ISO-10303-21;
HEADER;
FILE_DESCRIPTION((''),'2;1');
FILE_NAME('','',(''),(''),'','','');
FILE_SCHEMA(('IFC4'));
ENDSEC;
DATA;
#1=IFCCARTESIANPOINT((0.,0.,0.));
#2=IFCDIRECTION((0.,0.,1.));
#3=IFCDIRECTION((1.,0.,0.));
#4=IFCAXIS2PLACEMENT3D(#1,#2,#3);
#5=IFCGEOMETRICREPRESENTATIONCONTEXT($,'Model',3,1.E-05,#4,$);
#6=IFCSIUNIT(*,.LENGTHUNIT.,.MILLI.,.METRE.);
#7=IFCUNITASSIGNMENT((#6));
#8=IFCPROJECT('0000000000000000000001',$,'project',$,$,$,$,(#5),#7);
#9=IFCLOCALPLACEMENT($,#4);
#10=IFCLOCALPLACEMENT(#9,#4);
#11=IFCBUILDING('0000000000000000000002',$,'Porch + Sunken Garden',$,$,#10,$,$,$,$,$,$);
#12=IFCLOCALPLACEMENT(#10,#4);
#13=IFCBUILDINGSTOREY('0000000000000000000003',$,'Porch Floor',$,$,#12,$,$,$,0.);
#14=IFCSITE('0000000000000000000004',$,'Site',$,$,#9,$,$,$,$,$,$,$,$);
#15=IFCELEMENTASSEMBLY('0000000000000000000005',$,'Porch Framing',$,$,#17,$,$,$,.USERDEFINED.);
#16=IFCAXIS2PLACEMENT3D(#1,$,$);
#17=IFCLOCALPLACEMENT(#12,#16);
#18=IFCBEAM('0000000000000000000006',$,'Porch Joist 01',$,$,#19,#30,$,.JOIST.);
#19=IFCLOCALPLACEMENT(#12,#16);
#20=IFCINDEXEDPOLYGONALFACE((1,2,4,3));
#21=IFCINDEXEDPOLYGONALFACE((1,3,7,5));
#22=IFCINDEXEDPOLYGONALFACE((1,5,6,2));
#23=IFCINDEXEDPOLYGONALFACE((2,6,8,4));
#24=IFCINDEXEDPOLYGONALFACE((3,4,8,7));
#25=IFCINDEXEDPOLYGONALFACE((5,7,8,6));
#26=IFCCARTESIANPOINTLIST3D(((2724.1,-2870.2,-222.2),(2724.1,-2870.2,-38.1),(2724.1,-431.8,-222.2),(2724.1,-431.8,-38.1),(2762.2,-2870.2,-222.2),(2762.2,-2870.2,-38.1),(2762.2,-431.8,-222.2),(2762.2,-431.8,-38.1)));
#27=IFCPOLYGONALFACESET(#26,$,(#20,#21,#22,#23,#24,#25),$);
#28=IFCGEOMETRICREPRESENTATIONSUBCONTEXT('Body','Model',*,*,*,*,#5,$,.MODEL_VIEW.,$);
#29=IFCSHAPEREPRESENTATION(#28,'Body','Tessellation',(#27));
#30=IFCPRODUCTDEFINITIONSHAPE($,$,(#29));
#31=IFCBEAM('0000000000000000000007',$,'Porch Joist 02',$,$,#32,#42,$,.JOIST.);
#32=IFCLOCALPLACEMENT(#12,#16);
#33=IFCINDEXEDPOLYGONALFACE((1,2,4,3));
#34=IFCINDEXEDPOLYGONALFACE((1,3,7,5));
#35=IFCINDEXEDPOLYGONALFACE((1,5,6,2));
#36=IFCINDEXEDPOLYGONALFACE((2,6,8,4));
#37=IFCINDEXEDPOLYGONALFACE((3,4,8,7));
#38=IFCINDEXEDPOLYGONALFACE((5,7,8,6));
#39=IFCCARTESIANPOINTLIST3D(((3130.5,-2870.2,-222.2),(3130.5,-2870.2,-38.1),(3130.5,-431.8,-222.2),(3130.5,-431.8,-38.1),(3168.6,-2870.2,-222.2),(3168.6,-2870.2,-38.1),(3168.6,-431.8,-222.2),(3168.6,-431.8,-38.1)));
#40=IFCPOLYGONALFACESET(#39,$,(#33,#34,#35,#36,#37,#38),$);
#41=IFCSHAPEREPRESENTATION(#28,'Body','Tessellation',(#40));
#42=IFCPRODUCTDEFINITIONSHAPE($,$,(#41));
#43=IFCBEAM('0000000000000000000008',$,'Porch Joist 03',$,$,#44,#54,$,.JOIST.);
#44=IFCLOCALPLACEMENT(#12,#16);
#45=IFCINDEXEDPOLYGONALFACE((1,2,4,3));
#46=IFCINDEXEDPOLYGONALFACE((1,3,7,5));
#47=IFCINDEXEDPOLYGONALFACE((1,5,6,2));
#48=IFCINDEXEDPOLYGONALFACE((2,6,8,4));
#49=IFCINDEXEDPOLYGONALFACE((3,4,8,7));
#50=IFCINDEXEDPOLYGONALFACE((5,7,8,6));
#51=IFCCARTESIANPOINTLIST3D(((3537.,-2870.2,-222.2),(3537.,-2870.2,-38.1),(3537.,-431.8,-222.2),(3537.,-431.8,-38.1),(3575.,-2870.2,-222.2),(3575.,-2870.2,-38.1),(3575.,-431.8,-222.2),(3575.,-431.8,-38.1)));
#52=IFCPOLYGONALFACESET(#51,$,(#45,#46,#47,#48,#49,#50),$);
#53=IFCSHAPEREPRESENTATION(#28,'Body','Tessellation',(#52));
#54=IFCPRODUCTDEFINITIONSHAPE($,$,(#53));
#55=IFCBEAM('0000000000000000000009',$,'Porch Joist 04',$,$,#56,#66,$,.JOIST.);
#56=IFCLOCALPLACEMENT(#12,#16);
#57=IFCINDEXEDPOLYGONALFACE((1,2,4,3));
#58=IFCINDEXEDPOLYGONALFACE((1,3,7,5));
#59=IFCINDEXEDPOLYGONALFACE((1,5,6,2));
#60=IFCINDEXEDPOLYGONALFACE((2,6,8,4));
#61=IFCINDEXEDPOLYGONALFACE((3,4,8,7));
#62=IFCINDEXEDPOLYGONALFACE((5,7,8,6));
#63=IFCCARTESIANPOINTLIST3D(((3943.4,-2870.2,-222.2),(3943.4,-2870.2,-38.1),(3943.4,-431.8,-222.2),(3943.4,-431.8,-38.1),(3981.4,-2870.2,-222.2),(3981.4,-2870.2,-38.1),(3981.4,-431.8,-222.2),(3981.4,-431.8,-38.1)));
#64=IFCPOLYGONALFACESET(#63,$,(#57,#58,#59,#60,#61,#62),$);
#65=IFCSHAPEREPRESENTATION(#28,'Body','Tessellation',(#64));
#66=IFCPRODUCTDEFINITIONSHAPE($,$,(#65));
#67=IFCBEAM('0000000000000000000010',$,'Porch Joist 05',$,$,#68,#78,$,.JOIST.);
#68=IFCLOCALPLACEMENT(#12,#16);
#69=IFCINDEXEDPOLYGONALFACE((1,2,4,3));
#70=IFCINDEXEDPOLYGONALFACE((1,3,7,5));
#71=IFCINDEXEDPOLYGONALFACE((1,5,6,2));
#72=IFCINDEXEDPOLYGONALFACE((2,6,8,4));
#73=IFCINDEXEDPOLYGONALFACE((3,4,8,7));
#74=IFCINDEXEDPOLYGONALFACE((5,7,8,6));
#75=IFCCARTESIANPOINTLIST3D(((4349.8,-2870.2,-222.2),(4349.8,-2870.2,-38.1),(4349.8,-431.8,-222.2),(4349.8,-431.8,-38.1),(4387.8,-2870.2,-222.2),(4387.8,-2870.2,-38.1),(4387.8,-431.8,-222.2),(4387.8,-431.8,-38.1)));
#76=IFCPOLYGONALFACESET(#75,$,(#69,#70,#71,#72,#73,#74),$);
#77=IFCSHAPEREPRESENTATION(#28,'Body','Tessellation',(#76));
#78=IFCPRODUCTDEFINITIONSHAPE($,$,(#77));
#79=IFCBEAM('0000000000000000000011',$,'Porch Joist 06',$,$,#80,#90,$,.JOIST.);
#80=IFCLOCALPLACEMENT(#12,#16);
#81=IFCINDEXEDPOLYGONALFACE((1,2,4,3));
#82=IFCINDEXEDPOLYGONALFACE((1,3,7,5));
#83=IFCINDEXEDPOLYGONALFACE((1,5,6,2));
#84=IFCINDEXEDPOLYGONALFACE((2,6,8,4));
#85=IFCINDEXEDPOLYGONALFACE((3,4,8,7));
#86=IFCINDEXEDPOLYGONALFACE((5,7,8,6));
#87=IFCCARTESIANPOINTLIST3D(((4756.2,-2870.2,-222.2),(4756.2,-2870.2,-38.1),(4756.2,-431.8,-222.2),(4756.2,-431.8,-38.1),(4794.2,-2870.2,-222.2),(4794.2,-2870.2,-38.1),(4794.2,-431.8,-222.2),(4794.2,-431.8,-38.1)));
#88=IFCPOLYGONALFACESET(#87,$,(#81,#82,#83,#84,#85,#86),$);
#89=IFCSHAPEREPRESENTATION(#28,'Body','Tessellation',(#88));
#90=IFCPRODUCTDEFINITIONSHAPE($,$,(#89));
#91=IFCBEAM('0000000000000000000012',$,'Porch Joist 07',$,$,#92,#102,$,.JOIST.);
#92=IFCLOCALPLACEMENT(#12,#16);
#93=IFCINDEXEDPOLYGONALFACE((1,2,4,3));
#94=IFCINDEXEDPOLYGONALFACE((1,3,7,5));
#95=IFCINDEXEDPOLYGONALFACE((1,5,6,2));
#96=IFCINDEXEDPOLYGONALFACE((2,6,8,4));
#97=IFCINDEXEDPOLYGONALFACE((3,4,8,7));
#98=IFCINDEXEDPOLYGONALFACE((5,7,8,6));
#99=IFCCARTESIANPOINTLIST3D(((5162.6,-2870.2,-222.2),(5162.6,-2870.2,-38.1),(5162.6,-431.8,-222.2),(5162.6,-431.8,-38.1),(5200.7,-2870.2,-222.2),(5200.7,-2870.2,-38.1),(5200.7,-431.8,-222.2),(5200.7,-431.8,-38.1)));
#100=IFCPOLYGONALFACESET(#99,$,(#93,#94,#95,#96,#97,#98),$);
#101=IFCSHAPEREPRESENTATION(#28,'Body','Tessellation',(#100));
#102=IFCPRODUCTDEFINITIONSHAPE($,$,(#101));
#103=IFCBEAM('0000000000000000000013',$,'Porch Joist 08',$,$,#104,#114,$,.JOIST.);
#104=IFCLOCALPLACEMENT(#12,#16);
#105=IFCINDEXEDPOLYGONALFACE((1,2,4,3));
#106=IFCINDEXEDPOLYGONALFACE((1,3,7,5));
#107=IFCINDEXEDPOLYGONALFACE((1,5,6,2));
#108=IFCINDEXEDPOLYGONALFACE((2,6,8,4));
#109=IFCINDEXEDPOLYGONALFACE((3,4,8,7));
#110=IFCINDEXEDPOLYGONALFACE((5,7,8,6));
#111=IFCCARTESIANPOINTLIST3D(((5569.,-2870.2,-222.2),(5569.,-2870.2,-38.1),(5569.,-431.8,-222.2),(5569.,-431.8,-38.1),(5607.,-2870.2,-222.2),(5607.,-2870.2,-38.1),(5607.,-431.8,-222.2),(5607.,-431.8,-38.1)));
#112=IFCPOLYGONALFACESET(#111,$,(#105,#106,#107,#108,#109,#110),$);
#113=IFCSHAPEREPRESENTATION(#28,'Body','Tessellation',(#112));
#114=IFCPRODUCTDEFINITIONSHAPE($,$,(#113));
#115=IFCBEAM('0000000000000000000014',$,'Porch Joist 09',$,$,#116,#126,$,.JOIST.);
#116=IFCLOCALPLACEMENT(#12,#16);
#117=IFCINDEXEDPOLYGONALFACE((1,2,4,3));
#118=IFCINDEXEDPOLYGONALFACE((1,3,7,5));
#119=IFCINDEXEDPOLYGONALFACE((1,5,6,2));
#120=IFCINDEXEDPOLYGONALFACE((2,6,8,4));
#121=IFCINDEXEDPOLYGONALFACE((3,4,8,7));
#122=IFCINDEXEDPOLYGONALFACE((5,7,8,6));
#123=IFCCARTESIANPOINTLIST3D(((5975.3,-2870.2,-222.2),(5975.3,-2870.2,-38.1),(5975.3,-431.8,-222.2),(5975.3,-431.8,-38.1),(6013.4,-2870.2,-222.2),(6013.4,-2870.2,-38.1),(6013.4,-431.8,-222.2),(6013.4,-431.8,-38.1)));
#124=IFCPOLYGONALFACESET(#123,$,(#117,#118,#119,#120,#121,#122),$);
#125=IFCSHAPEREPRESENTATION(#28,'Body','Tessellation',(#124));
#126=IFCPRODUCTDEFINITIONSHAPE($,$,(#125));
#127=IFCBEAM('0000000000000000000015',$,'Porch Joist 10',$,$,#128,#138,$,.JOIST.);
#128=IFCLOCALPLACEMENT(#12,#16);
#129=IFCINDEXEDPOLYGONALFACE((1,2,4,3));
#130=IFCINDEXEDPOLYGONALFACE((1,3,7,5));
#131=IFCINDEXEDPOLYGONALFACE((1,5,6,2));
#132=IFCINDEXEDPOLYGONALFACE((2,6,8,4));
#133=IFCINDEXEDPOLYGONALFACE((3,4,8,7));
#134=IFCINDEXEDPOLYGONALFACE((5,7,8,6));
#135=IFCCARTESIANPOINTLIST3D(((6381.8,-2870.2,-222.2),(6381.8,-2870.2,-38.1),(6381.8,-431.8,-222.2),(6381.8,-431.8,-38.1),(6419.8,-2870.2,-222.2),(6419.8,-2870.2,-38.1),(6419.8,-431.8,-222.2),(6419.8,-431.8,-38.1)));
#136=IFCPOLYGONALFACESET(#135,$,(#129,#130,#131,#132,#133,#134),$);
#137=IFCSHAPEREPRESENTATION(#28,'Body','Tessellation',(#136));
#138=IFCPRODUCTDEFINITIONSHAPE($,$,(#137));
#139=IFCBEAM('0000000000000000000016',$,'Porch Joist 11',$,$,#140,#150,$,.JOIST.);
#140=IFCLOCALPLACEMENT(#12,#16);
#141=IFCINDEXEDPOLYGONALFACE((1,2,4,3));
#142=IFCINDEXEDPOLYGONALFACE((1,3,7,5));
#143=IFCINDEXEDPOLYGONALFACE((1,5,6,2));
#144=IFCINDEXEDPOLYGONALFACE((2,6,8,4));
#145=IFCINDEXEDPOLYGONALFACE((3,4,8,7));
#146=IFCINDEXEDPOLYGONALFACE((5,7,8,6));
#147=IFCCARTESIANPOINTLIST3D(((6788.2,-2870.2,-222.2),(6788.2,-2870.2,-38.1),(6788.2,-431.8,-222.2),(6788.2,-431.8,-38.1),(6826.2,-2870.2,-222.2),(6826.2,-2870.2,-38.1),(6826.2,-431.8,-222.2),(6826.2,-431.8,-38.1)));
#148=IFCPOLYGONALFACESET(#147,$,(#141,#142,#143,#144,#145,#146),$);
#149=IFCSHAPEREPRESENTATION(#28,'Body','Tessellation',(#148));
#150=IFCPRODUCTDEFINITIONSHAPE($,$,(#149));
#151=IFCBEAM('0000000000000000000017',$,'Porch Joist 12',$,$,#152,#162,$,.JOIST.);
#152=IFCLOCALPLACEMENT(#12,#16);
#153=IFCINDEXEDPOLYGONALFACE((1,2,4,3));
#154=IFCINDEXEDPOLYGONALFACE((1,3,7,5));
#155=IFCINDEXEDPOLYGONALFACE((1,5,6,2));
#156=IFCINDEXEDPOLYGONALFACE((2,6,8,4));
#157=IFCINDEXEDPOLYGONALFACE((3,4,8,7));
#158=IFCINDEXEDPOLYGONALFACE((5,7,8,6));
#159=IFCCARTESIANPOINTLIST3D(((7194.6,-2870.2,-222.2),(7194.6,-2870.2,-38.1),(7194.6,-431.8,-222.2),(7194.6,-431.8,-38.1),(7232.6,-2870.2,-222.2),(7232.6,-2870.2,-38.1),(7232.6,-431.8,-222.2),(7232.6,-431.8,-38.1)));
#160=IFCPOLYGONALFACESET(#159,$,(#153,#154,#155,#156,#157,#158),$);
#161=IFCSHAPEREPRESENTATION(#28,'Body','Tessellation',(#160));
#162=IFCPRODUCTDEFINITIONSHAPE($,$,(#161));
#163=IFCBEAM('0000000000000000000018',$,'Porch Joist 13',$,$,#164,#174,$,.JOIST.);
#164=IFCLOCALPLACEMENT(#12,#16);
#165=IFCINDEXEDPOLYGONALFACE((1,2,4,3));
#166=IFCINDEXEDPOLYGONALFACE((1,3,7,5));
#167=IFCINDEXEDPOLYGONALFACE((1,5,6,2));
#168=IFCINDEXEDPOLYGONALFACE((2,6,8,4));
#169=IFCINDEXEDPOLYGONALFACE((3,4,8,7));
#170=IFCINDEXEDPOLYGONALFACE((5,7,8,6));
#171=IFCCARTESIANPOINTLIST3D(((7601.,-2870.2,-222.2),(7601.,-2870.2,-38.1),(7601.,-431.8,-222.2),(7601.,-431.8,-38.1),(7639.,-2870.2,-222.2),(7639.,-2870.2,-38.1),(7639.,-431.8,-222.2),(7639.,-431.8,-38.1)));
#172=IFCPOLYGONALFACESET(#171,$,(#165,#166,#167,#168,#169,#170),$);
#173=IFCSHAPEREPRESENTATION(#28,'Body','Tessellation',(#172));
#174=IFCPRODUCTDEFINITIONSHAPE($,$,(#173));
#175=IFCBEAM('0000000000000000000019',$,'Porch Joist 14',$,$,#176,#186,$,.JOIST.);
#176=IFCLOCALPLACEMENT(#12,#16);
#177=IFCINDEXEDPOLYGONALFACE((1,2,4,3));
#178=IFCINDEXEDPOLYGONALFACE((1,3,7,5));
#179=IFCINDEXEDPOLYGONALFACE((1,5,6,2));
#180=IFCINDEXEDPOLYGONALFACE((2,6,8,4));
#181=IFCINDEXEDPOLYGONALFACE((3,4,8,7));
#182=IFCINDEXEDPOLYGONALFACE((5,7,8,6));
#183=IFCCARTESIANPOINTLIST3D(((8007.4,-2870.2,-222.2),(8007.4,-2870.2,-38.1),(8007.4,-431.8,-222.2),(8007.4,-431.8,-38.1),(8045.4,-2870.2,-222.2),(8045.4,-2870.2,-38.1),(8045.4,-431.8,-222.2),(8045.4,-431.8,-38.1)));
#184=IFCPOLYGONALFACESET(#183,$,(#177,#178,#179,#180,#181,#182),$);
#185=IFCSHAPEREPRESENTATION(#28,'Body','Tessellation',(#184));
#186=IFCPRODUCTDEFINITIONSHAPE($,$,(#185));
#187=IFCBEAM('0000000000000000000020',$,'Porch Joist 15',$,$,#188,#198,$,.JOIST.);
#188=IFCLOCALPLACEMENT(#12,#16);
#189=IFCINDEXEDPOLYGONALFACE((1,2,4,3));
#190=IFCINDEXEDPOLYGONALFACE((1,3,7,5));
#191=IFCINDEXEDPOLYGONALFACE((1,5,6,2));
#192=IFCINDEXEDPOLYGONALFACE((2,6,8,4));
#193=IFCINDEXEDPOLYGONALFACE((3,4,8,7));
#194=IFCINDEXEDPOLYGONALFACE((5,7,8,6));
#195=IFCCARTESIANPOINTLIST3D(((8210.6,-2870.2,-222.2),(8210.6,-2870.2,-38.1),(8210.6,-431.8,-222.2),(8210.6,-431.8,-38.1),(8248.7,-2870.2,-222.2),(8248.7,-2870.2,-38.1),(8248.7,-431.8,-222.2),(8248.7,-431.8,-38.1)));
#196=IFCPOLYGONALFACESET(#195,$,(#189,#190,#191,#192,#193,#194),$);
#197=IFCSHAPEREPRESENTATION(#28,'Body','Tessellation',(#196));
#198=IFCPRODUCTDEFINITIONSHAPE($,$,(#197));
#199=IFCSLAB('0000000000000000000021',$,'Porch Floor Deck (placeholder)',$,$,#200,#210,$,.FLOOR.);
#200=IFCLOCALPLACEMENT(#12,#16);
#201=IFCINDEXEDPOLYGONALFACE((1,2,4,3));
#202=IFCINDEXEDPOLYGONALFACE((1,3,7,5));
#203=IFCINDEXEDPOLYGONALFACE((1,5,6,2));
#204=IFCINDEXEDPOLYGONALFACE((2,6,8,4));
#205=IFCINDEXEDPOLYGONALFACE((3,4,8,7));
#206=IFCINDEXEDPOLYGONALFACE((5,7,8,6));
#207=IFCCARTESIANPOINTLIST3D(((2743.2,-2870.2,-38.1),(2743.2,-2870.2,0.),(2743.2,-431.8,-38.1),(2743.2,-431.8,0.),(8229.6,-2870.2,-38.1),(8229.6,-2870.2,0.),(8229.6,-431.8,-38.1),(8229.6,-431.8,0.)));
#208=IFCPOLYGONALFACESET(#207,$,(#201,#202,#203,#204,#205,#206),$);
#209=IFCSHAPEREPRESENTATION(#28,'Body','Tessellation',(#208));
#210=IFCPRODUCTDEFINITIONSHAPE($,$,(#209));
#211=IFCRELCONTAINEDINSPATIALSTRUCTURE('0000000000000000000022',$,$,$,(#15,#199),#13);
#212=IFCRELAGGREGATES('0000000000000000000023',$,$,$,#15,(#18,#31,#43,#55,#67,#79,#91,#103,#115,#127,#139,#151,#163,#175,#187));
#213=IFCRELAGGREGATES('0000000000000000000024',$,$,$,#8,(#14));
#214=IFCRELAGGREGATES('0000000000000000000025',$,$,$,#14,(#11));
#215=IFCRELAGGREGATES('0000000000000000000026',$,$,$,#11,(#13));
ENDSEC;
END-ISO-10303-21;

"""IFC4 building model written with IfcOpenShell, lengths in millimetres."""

from ifc_helpers import new_model, si_unit, frame, origin_with_axes, origin_2d, place, context, subcontext, project, spatial, indexed_curve, rectangle, outline, extrude, element, aggregate, save


model = new_model("IFC4")

# Units and contexts
model_context = context("Model", 3, precision=1e-05, world=origin_with_axes())
body_context = subcontext(model_context, "Body", "Model", "MODEL_VIEW")
ifc_project = project(units=[si_unit("LENGTHUNIT", "METRE", prefix="MILLI")], contexts=[model_context])

# Site, building, storey
site_placement = place(None, origin_with_axes())
site = spatial("IfcSite", under=ifc_project, at=site_placement, Name="Site")
building_placement = place(site_placement, origin_with_axes())
building = spatial("IfcBuilding", under=site, at=building_placement, Name="Porch + Sunken Garden")
storey_placement = place(building_placement, origin_with_axes())
storey = spatial("IfcBuildingStorey", under=building, at=storey_placement, Name="Porch Floor", Elevation=0.0)

# Element assembly, beams
assembly_placement = place(storey_placement, origin_with_axes())
assembly = element("IfcElementAssembly", 1, at=assembly_placement, inside=storey, Name="Porch Framing", PredefinedType="USERDEFINED")
beam_1_placement = place(assembly_placement, frame((2743.2, -431.8, -130.2), z_axis=(0.0, -1.0, 0.0), x_axis=(1.0, 0.0, 0.0)))
beam_1 = element("IfcBeam", 2, at=beam_1_placement, Name="Porch Joist 01", PredefinedType="JOIST", context=body_context, shape_type="SweptSolid", body=[
    extrude(rectangle(XDim=38.1, YDim=184.2, at=origin_2d()), origin_with_axes(), (0.0, 0.0, 1.0), 2438.4),
])
beam_2_placement = place(assembly_placement, frame((3149.6, -431.8, -130.2), z_axis=(0.0, -1.0, 0.0), x_axis=(1.0, 0.0, 0.0)))
beam_2 = element("IfcBeam", 3, at=beam_2_placement, Name="Porch Joist 02", PredefinedType="JOIST", context=body_context, shape_type="SweptSolid", body=[
    extrude(rectangle(XDim=38.1, YDim=184.2, at=origin_2d()), origin_with_axes(), (0.0, 0.0, 1.0), 2438.4),
])
beam_3_placement = place(assembly_placement, frame((3556.0, -431.8, -130.2), z_axis=(0.0, -1.0, 0.0), x_axis=(1.0, 0.0, 0.0)))
beam_3 = element("IfcBeam", 4, at=beam_3_placement, Name="Porch Joist 03", PredefinedType="JOIST", context=body_context, shape_type="SweptSolid", body=[
    extrude(rectangle(XDim=38.1, YDim=184.2, at=origin_2d()), origin_with_axes(), (0.0, 0.0, 1.0), 2438.4),
])
beam_4_placement = place(assembly_placement, frame((3962.4, -431.8, -130.2), z_axis=(0.0, -1.0, 0.0), x_axis=(1.0, 0.0, 0.0)))
beam_4 = element("IfcBeam", 5, at=beam_4_placement, Name="Porch Joist 04", PredefinedType="JOIST", context=body_context, shape_type="SweptSolid", body=[
    extrude(rectangle(XDim=38.1, YDim=184.2, at=origin_2d()), origin_with_axes(), (0.0, 0.0, 1.0), 2438.4),
])
beam_5_placement = place(assembly_placement, frame((4368.8, -431.8, -130.2), z_axis=(0.0, -1.0, 0.0), x_axis=(1.0, 0.0, 0.0)))
beam_5 = element("IfcBeam", 6, at=beam_5_placement, Name="Porch Joist 05", PredefinedType="JOIST", context=body_context, shape_type="SweptSolid", body=[
    extrude(rectangle(XDim=38.1, YDim=184.2, at=origin_2d()), origin_with_axes(), (0.0, 0.0, 1.0), 2438.4),
])
beam_6_placement = place(assembly_placement, frame((4775.2, -431.8, -130.2), z_axis=(0.0, -1.0, 0.0), x_axis=(1.0, 0.0, 0.0)))
beam_6 = element("IfcBeam", 7, at=beam_6_placement, Name="Porch Joist 06", PredefinedType="JOIST", context=body_context, shape_type="SweptSolid", body=[
    extrude(rectangle(XDim=38.1, YDim=184.2, at=origin_2d()), origin_with_axes(), (0.0, 0.0, 1.0), 2438.4),
])
beam_7_placement = place(assembly_placement, frame((5181.6, -431.8, -130.2), z_axis=(0.0, -1.0, 0.0), x_axis=(1.0, 0.0, 0.0)))
beam_7 = element("IfcBeam", 8, at=beam_7_placement, Name="Porch Joist 07", PredefinedType="JOIST", context=body_context, shape_type="SweptSolid", body=[
    extrude(rectangle(XDim=38.1, YDim=184.2, at=origin_2d()), origin_with_axes(), (0.0, 0.0, 1.0), 2438.4),
])
beam_8_placement = place(assembly_placement, frame((5588.0, -431.8, -130.2), z_axis=(0.0, -1.0, 0.0), x_axis=(1.0, 0.0, 0.0)))
beam_8 = element("IfcBeam", 9, at=beam_8_placement, Name="Porch Joist 08", PredefinedType="JOIST", context=body_context, shape_type="SweptSolid", body=[
    extrude(rectangle(XDim=38.1, YDim=184.2, at=origin_2d()), origin_with_axes(), (0.0, 0.0, 1.0), 2438.4),
])
beam_9_placement = place(assembly_placement, frame((5994.4, -431.8, -130.2), z_axis=(0.0, -1.0, 0.0), x_axis=(1.0, 0.0, 0.0)))
beam_9 = element("IfcBeam", 10, at=beam_9_placement, Name="Porch Joist 09", PredefinedType="JOIST", context=body_context, shape_type="SweptSolid", body=[
    extrude(rectangle(XDim=38.1, YDim=184.2, at=origin_2d()), origin_with_axes(), (0.0, 0.0, 1.0), 2438.4),
])
beam_10_placement = place(assembly_placement, frame((6400.8, -431.8, -130.2), z_axis=(0.0, -1.0, 0.0), x_axis=(1.0, 0.0, 0.0)))
beam_10 = element("IfcBeam", 11, at=beam_10_placement, Name="Porch Joist 10", PredefinedType="JOIST", context=body_context, shape_type="SweptSolid", body=[
    extrude(rectangle(XDim=38.1, YDim=184.2, at=origin_2d()), origin_with_axes(), (0.0, 0.0, 1.0), 2438.4),
])
beam_11_placement = place(assembly_placement, frame((6807.2, -431.8, -130.2), z_axis=(0.0, -1.0, 0.0), x_axis=(1.0, 0.0, 0.0)))
beam_11 = element("IfcBeam", 12, at=beam_11_placement, Name="Porch Joist 11", PredefinedType="JOIST", context=body_context, shape_type="SweptSolid", body=[
    extrude(rectangle(XDim=38.1, YDim=184.2, at=origin_2d()), origin_with_axes(), (0.0, 0.0, 1.0), 2438.4),
])
beam_12_placement = place(assembly_placement, frame((7213.6, -431.8, -130.2), z_axis=(0.0, -1.0, 0.0), x_axis=(1.0, 0.0, 0.0)))
beam_12 = element("IfcBeam", 13, at=beam_12_placement, Name="Porch Joist 12", PredefinedType="JOIST", context=body_context, shape_type="SweptSolid", body=[
    extrude(rectangle(XDim=38.1, YDim=184.2, at=origin_2d()), origin_with_axes(), (0.0, 0.0, 1.0), 2438.4),
])
beam_13_placement = place(assembly_placement, frame((7620.0, -431.8, -130.2), z_axis=(0.0, -1.0, 0.0), x_axis=(1.0, 0.0, 0.0)))
beam_13 = element("IfcBeam", 14, at=beam_13_placement, Name="Porch Joist 13", PredefinedType="JOIST", context=body_context, shape_type="SweptSolid", body=[
    extrude(rectangle(XDim=38.1, YDim=184.2, at=origin_2d()), origin_with_axes(), (0.0, 0.0, 1.0), 2438.4),
])
beam_14_placement = place(assembly_placement, frame((8026.4, -431.8, -130.2), z_axis=(0.0, -1.0, 0.0), x_axis=(1.0, 0.0, 0.0)))
beam_14 = element("IfcBeam", 15, at=beam_14_placement, Name="Porch Joist 14", PredefinedType="JOIST", context=body_context, shape_type="SweptSolid", body=[
    extrude(rectangle(XDim=38.1, YDim=184.2, at=origin_2d()), origin_with_axes(), (0.0, 0.0, 1.0), 2438.4),
])
beam_15_placement = place(assembly_placement, frame((8229.6, -431.8, -130.2), z_axis=(0.0, -1.0, 0.0), x_axis=(1.0, 0.0, 0.0)))
beam_15 = element("IfcBeam", 16, at=beam_15_placement, Name="Porch Joist 15", PredefinedType="JOIST", context=body_context, shape_type="SweptSolid", body=[
    extrude(rectangle(XDim=38.1, YDim=184.2, at=origin_2d()), origin_with_axes(), (0.0, 0.0, 1.0), 2438.4),
])
aggregate(assembly, [beam_1, beam_2, beam_3, beam_4, beam_5, beam_6, beam_7, beam_8, beam_9, beam_10, beam_11, beam_12, beam_13, beam_14, beam_15])

# Slab
slab_placement = place(storey_placement, frame((2743.2, -2870.2, -38.1), z_axis=(0.0, 0.0, 1.0), x_axis=(1.0, 0.0, 0.0)))
element("IfcSlab", 17, at=slab_placement, inside=storey, Name="Porch Floor Deck (placeholder)", PredefinedType="FLOOR", context=body_context, shape_type="SweptSolid", body=[
    extrude(outline(indexed_curve([(0.0, 0.0), (5486.4, 0.0), (5486.4, 2438.4), (0.0, 2438.4), (0.0, 0.0)])), origin_with_axes(), (0.0, 0.0, 1.0), 38.1),
])

save(model, "model.ifc")
